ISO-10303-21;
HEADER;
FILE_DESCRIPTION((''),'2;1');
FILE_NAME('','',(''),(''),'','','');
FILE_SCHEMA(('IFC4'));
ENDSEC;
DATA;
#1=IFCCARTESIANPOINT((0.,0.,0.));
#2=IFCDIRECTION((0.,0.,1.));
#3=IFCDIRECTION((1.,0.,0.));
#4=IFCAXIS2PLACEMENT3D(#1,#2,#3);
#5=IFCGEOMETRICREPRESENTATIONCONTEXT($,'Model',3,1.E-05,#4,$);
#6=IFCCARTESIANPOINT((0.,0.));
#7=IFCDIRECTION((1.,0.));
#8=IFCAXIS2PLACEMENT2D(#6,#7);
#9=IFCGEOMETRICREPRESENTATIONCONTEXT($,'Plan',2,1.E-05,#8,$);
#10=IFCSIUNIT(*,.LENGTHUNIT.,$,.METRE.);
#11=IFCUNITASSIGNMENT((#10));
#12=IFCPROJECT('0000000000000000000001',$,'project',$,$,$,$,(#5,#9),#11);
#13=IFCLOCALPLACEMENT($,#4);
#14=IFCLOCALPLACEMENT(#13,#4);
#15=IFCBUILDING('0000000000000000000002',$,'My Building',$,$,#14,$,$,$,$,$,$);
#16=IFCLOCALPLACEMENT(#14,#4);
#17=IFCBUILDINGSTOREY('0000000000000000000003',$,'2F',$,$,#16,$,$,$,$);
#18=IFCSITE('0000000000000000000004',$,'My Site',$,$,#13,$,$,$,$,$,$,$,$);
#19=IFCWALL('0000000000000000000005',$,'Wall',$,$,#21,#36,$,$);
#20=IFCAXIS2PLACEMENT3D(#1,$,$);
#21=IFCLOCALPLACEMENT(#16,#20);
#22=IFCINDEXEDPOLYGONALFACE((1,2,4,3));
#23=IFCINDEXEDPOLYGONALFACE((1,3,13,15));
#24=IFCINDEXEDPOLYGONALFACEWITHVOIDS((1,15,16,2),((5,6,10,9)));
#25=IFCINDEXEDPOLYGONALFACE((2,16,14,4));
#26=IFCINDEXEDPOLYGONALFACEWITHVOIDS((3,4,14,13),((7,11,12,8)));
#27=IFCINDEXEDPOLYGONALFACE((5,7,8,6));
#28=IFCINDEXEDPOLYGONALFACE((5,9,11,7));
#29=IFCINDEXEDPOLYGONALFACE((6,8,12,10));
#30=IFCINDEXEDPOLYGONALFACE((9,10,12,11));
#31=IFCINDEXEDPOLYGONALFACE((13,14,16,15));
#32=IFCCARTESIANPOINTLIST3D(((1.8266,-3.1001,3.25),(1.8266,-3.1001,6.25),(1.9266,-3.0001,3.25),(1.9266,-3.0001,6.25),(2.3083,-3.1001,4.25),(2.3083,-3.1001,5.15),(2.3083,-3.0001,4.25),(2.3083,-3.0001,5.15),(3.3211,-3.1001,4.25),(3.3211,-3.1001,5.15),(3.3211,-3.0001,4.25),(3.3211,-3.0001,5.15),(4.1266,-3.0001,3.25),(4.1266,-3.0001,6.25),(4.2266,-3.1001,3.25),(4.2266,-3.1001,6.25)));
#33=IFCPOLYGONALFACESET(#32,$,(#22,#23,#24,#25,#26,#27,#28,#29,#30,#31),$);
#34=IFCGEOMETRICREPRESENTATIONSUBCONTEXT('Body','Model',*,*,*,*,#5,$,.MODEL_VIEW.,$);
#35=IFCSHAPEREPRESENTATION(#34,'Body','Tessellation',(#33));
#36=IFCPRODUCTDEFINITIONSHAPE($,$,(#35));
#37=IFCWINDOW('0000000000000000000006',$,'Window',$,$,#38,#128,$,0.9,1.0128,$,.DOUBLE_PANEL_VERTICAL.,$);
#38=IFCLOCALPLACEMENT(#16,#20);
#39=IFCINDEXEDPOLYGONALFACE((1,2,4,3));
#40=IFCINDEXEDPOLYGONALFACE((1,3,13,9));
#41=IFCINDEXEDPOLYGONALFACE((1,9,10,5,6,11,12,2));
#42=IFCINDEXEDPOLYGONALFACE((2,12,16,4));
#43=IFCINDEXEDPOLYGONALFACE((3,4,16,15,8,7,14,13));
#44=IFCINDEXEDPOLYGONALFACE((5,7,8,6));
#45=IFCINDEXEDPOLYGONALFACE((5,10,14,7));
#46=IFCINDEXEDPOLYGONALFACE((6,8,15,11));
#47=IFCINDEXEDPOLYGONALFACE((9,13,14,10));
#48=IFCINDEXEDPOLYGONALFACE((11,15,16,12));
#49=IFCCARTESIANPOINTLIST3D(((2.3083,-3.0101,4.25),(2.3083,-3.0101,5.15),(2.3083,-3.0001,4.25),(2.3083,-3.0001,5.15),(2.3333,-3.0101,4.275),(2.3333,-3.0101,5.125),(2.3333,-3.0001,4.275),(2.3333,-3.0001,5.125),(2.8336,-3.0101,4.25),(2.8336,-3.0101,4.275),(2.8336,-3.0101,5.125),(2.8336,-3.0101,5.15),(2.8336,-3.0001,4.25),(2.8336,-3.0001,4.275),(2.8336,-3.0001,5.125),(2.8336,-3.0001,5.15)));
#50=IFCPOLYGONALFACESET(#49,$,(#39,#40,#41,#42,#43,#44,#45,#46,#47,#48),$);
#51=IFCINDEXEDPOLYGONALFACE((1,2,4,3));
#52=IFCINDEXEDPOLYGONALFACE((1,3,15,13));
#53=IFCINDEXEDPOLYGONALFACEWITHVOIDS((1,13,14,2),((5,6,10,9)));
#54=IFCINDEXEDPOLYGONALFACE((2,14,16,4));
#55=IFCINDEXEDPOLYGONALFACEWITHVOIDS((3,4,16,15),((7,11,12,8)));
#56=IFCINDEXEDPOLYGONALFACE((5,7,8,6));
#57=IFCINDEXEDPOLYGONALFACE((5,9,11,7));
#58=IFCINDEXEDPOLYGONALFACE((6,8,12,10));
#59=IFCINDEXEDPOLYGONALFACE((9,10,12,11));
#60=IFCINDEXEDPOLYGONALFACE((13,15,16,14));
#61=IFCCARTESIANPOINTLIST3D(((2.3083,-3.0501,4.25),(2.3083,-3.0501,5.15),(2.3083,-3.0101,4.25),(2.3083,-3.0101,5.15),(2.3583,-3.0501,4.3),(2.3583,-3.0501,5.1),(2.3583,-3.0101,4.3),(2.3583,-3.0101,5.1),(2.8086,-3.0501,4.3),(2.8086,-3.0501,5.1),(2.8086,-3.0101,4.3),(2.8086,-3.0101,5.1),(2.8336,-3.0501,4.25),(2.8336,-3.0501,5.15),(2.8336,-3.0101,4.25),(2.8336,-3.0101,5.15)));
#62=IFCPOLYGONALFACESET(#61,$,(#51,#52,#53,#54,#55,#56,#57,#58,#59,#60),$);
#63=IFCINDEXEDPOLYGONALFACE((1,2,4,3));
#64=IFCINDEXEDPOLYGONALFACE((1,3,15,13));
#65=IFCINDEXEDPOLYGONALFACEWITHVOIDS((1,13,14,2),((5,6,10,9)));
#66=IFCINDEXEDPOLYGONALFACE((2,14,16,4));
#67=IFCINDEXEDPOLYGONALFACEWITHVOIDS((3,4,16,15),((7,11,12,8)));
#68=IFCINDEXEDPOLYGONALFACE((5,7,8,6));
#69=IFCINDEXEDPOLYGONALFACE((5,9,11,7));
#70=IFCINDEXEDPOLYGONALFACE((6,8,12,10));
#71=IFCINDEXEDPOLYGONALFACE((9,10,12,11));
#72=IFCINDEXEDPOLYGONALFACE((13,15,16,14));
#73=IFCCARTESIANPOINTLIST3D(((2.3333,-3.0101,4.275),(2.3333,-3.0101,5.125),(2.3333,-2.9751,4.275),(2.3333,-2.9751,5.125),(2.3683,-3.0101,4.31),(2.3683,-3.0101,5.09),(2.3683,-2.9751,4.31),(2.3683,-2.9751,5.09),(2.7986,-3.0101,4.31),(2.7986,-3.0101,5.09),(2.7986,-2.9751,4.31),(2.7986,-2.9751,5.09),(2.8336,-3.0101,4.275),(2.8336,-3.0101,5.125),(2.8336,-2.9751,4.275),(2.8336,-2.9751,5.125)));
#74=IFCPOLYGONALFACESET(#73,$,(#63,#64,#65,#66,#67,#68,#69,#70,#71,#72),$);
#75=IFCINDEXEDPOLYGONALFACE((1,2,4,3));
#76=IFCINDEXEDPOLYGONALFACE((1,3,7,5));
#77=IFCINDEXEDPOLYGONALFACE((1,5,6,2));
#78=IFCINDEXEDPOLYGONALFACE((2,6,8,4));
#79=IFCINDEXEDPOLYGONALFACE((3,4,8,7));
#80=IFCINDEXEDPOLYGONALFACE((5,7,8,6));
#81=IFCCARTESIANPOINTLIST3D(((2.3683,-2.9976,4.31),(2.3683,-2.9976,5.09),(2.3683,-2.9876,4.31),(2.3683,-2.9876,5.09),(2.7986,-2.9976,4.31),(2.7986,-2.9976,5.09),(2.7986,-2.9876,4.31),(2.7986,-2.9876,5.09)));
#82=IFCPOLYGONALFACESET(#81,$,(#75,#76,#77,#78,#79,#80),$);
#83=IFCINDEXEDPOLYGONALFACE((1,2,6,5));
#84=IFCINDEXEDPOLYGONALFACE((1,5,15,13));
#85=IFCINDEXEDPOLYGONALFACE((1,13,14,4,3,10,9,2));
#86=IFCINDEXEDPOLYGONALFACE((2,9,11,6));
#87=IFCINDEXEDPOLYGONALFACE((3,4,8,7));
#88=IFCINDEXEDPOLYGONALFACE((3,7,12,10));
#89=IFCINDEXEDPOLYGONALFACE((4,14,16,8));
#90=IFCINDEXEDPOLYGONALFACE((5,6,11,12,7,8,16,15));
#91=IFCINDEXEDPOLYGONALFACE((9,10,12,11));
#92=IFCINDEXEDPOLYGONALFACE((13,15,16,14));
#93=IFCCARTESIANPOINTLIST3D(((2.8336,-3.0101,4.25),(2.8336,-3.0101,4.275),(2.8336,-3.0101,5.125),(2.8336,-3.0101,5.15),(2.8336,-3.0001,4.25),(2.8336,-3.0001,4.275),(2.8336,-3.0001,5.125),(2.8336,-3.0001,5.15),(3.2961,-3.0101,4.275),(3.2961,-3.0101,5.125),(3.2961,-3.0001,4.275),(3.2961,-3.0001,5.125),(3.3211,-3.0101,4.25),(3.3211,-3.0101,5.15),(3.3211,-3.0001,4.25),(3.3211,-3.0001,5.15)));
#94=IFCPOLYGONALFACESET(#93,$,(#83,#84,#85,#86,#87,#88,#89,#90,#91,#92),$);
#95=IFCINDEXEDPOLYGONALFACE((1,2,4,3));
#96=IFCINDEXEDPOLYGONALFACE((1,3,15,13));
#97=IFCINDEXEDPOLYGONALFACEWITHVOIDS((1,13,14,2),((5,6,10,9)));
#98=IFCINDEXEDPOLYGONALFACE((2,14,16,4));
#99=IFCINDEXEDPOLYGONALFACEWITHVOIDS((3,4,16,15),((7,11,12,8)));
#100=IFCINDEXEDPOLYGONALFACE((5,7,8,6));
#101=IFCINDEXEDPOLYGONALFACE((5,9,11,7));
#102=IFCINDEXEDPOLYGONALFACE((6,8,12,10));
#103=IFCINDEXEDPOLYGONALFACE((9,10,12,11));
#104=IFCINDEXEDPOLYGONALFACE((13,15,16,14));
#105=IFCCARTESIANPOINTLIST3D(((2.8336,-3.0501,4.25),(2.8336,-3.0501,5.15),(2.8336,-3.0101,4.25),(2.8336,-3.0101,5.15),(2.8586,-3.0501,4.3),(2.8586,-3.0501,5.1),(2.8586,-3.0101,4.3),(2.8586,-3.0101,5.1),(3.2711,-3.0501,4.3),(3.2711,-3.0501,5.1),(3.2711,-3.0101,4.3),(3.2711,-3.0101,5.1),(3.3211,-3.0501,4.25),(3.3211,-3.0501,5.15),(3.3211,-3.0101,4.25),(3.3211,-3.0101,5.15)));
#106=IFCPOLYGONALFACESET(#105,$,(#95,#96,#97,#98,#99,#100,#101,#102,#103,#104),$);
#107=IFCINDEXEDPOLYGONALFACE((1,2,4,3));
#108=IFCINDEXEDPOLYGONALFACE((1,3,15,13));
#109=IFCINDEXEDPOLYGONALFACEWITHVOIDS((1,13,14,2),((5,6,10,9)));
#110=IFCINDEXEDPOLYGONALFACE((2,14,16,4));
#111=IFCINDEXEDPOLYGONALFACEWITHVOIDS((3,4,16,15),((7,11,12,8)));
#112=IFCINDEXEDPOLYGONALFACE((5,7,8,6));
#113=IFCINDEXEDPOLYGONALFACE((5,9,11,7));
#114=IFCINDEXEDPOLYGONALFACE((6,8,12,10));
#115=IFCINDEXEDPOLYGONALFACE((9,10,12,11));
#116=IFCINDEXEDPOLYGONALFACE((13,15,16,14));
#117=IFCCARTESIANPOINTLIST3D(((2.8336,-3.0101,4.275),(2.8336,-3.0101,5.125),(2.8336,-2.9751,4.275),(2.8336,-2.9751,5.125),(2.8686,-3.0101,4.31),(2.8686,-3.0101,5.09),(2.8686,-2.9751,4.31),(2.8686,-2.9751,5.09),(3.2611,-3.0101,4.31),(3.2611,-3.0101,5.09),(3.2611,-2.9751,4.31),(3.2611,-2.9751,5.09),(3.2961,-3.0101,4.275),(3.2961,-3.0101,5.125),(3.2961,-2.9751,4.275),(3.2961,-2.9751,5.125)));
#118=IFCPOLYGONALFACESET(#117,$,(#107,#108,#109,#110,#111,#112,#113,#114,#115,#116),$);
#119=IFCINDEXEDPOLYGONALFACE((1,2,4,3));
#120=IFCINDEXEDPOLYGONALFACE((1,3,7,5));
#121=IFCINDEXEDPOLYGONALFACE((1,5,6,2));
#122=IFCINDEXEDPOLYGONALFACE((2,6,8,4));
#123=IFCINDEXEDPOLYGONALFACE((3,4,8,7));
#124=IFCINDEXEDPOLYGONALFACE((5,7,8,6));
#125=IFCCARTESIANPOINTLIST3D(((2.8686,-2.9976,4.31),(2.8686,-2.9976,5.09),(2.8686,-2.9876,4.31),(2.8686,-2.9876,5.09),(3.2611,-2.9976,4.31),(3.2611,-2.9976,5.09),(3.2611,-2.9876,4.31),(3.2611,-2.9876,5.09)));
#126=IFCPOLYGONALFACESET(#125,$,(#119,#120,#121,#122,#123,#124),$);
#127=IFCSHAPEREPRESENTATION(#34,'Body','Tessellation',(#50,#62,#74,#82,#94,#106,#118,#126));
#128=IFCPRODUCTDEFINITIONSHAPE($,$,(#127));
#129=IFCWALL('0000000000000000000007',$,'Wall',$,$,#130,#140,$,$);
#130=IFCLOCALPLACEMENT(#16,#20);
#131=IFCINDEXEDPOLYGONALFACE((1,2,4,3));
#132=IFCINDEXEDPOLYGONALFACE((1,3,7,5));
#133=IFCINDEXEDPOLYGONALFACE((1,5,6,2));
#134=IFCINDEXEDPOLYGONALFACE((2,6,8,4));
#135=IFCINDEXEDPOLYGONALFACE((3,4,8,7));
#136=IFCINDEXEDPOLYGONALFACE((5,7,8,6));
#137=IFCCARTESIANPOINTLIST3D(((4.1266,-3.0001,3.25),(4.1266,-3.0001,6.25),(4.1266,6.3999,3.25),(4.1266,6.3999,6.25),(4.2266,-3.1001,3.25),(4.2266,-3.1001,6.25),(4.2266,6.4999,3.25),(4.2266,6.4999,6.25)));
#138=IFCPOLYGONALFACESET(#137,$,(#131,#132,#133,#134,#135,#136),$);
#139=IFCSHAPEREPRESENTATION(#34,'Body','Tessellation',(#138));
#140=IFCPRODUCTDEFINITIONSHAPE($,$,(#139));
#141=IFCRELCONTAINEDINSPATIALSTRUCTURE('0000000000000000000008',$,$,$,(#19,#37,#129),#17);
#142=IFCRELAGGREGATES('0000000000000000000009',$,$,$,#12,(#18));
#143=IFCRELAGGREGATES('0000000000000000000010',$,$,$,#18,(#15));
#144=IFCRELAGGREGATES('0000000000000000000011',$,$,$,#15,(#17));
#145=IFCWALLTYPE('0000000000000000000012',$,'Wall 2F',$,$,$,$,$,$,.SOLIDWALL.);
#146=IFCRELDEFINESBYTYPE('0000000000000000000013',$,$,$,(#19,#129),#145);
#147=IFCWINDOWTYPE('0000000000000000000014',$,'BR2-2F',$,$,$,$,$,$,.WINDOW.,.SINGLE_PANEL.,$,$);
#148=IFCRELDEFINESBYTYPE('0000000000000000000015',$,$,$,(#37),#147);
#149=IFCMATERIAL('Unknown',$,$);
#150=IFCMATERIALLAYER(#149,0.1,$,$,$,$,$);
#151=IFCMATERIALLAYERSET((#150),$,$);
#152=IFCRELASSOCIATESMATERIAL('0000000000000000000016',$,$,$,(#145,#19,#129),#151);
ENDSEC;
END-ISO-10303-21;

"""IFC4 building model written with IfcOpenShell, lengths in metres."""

from ifc_helpers import new_model, entity, si_unit, frame, origin_with_axes, origin_2d_with_axis, place, context, subcontext, project, spatial, line, indexed_curve, outline, extrude, shape, source, transform, mapped, material, layer, layer_set, layer_usage, type_object, type_shapes, element, fill, save


model = new_model("IFC4")

# Units and contexts
model_context = context("Model", 3, precision=1e-05, world=origin_with_axes())
plan_context = context("Plan", 2, precision=1e-05, world=origin_2d_with_axis())
body_context_1 = subcontext(model_context, "Body", "Model", "MODEL_VIEW")
body_context_2 = subcontext(plan_context, "Body", "Plan", "PLAN_VIEW")
ifc_project = project(units=[si_unit("LENGTHUNIT", "METRE")], contexts=[model_context, plan_context])

# Site, building, storey
site_placement = place(None, origin_with_axes())
site = spatial("IfcSite", under=ifc_project, at=site_placement, Name="My Site")
building_placement = place(site_placement, origin_with_axes())
building = spatial("IfcBuilding", under=site, at=building_placement, Name="My Building")
storey_placement = place(building_placement, origin_with_axes())
storey = spatial("IfcBuildingStorey", under=building, at=storey_placement, Name="2F")

# Shared definitions
ifc_material = material(Name="Unknown")

# Shared definitions
ifc_layer = layer(ifc_material, 0.1)
ifc_layer_set = layer_set([ifc_layer])
wall_type = type_object("IfcWallType", Name="Wall 2F", PredefinedType="SOLIDWALL", material=ifc_layer_set)

# Wall, opening, window
ifc_layer_usage_1 = layer_usage(ifc_layer_set, "AXIS2", "POSITIVE", 0.0)
wall_1_placement = place(storey_placement, frame((1.8266, -3.1001, 3.25), z_axis=(0.0, 0.0, 1.0), x_axis=(1.0, 0.0, 0.0)))
wall_1 = element("IfcWall", 1, at=wall_1_placement, inside=storey, type_object=wall_type, material=ifc_layer_usage_1, Name="Wall", context=body_context_1, shape_type="SweptSolid", body=[
    extrude(outline(indexed_curve([(0.0, 0.0), (0.1, 0.1), (2.3, 0.1), (2.4, 0.0)], segments=[line(1, 2, 3, 4, 1)])), origin_with_axes(), (0.0, 0.0, 1.0), 3.0),
])
shared_shape_1 = source(origin_with_axes(), body_context_1, "Body", "SweptSolid", [
    extrude(outline(indexed_curve([(0.0, 0.0), (1.0128, 0.0), (1.0128, 0.9), (0.0, 0.9)], segments=[line(1, 2, 3, 4, 1)])), frame((0.0, -0.6, 0.0), z_axis=(0.0, -1.0, 0.0), x_axis=(1.0, 0.0, 0.0)), (0.0, 0.0, -1.0), 1.2),
])
opening_1_placement = place(wall_1_placement, frame((0.4817, 0.0, 1.0), z_axis=(0.0, 0.0, 1.0), x_axis=(1.0, 0.0, 0.0)))
opening_1 = element("IfcOpeningElement", 2, at=opening_1_placement, cuts=wall_1, PredefinedType="OPENING", context=body_context_1, shape_type="MappedRepresentation", body=[
    mapped(shared_shape_1, transform((0.0, 0.0, 0.0), x_axis=(1.0, 0.0, 0.0), y_axis=(0.0, 1.0, 0.0), z_axis=(0.0, 0.0, 1.0), scale=1.0)),
])
window_type = type_object("IfcWindowType", Name="BR2-2F", PartitioningType="SINGLE_PANEL", PredefinedType="WINDOW")
shared_shape_2 = source(origin_with_axes(), body_context_1, "Body", "SweptSolid", [
    extrude(outline(indexed_curve([(0.5254, 0.0), (0.0, 0.0), (0.0, 0.9), (0.5254, 0.9), (0.5254, 0.875), (0.025, 0.875), (0.025, 0.025), (0.5254, 0.025)], segments=[line(1, 2, 3, 4, 5, 6, 7, 8, 1)])), frame((0.0, 0.09, 0.0), z_axis=(0.0, -1.0, 0.0), x_axis=(1.0, 0.0, 0.0)), (0.0, 0.0, -1.0), 0.01),
    extrude(outline(indexed_curve([(0.0, 0.0), (0.5254, 0.0), (0.5254, 0.9), (0.0, 0.9)], segments=[line(1, 2, 3, 4, 1)]), holes=[indexed_curve([(0.05, 0.05), (0.5004, 0.05), (0.5004, 0.85), (0.05, 0.85)], segments=[line(1, 2, 3, 4, 1)])]), frame((0.0, 0.05, 0.0), z_axis=(0.0, -1.0, 0.0), x_axis=(1.0, 0.0, 0.0)), (0.0, 0.0, -1.0), 0.04),
    extrude(outline(indexed_curve([(0.0, 0.0), (0.5004, 0.0), (0.5004, 0.85), (0.0, 0.85)], segments=[line(1, 2, 3, 4, 1)]), holes=[indexed_curve([(0.035, 0.035), (0.4654, 0.035), (0.4654, 0.815), (0.035, 0.815)], segments=[line(1, 2, 3, 4, 1)])]), frame((0.025, 0.09, 0.025), z_axis=(0.0, -1.0, 0.0), x_axis=(1.0, 0.0, 0.0)), (0.0, 0.0, -1.0), 0.035),
    extrude(outline(indexed_curve([(0.035, 0.035), (0.4654, 0.035), (0.4654, 0.815), (0.035, 0.815)], segments=[line(1, 2, 3, 4, 1)])), frame((0.025, 0.1025, 0.025), z_axis=(0.0, -1.0, 0.0), x_axis=(1.0, 0.0, 0.0)), (0.0, 0.0, -1.0), 0.01),
    extrude(outline(indexed_curve([(0.0, 0.9), (0.4875, 0.9), (0.4875, 0.0), (0.0, 0.0), (0.0, 0.025), (0.4625, 0.025), (0.4625, 0.875), (0.0, 0.875)], segments=[line(1, 2, 3, 4, 5, 6, 7, 8, 1)])), frame((0.5254, 0.09, 0.0), z_axis=(0.0, -1.0, 0.0), x_axis=(1.0, 0.0, 0.0)), (0.0, 0.0, -1.0), 0.01),
    extrude(outline(indexed_curve([(0.0, 0.0), (0.4875, 0.0), (0.4875, 0.9), (0.0, 0.9)], segments=[line(1, 2, 3, 4, 1)]), holes=[indexed_curve([(0.025, 0.05), (0.4375, 0.05), (0.4375, 0.85), (0.025, 0.85)], segments=[line(1, 2, 3, 4, 1)])]), frame((0.5254, 0.05, 0.0), z_axis=(0.0, -1.0, 0.0), x_axis=(1.0, 0.0, 0.0)), (0.0, 0.0, -1.0), 0.04),
    extrude(outline(indexed_curve([(0.0, 0.0), (0.4625, 0.0), (0.4625, 0.85), (0.0, 0.85)], segments=[line(1, 2, 3, 4, 1)]), holes=[indexed_curve([(0.035, 0.035), (0.4275, 0.035), (0.4275, 0.815), (0.035, 0.815)], segments=[line(1, 2, 3, 4, 1)])]), frame((0.5254, 0.09, 0.025), z_axis=(0.0, -1.0, 0.0), x_axis=(1.0, 0.0, 0.0)), (0.0, 0.0, -1.0), 0.035),
    extrude(outline(indexed_curve([(0.035, 0.035), (0.4275, 0.035), (0.4275, 0.815), (0.035, 0.815)], segments=[line(1, 2, 3, 4, 1)])), frame((0.5254, 0.1025, 0.025), z_axis=(0.0, -1.0, 0.0), x_axis=(1.0, 0.0, 0.0)), (0.0, 0.0, -1.0), 0.01),
])
shared_shape_3 = source(origin_with_axes(), body_context_2, "Body", "Curve2D", [
    entity("IfcIndexedPolyCurve", entity("IfcCartesianPointList2D", [[0.05, 0.05], [0.5004, 0.05]])),
    entity("IfcIndexedPolyCurve", entity("IfcCartesianPointList2D", [[0.0, 0.1], [0.025, 0.1], [0.025, 0.09], [0.05, 0.09], [0.05, 0.05], [0.0, 0.05]]), [entity("IfcLineIndex", [1, 2, 3, 4, 5, 6, 1])]),
    entity("IfcIndexedPolyCurve", entity("IfcCartesianPointList2D", [[0.5254, 0.1], [0.5254, 0.1], [0.5254, 0.09], [0.5004, 0.09], [0.5004, 0.05], [0.5254, 0.05]])),
    entity("IfcIndexedPolyCurve", entity("IfcCartesianPointList2D", [[0.025, 0.09], [0.06, 0.09], [0.06, 0.125], [0.025, 0.125]]), [entity("IfcLineIndex", [1, 2, 3, 4, 1])]),
    entity("IfcIndexedPolyCurve", entity("IfcCartesianPointList2D", [[0.5254, 0.09], [0.4904, 0.09], [0.4904, 0.125], [0.5254, 0.125]]), [entity("IfcLineIndex", [1, 2, 3, 4, 1])]),
    entity("IfcIndexedPolyCurve", entity("IfcCartesianPointList2D", [[0.06, 0.09], [0.4904, 0.09]])),
    entity("IfcIndexedPolyCurve", entity("IfcCartesianPointList2D", [[0.06, 0.125], [0.4904, 0.125]])),
    entity("IfcIndexedPolyCurve", entity("IfcCartesianPointList2D", [[0.06, 0.1075], [0.4904, 0.1075]])),
    entity("IfcIndexedPolyCurve", entity("IfcCartesianPointList2D", [[0.5504, 0.05], [0.9628, 0.05]])),
    entity("IfcIndexedPolyCurve", entity("IfcCartesianPointList2D", [[0.5254, 0.1], [0.5254, 0.1], [0.5254, 0.09], [0.5504, 0.09], [0.5504, 0.05], [0.5254, 0.05]])),
    entity("IfcIndexedPolyCurve", entity("IfcCartesianPointList2D", [[1.0128, 0.1], [0.9878, 0.1], [0.9878, 0.09], [0.9628, 0.09], [0.9628, 0.05], [1.0128, 0.05]]), [entity("IfcLineIndex", [1, 2, 3, 4, 5, 6, 1])]),
    entity("IfcIndexedPolyCurve", entity("IfcCartesianPointList2D", [[0.5254, 0.09], [0.5604, 0.09], [0.5604, 0.125], [0.5254, 0.125]]), [entity("IfcLineIndex", [1, 2, 3, 4, 1])]),
    entity("IfcIndexedPolyCurve", entity("IfcCartesianPointList2D", [[0.9878, 0.09], [0.9528, 0.09], [0.9528, 0.125], [0.9878, 0.125]]), [entity("IfcLineIndex", [1, 2, 3, 4, 1])]),
    entity("IfcIndexedPolyCurve", entity("IfcCartesianPointList2D", [[0.5604, 0.09], [0.9528, 0.09]])),
    entity("IfcIndexedPolyCurve", entity("IfcCartesianPointList2D", [[0.5604, 0.125], [0.9528, 0.125]])),
    entity("IfcIndexedPolyCurve", entity("IfcCartesianPointList2D", [[0.5604, 0.1075], [0.9528, 0.1075]])),
])
type_shapes(window_type, [shared_shape_2, shared_shape_3])
window_placement = place(opening_1_placement, frame((0.0, 0.0, 0.0), z_axis=(0.0, 0.0, 1.0), x_axis=(1.0, 0.0, 0.0)))
window = element("IfcWindow", 3, at=window_placement, inside=storey, type_object=window_type, Name="Window", OverallHeight=0.9, OverallWidth=1.0128, PartitioningType="DOUBLE_PANEL_VERTICAL", shapes=[
    shape(body_context_1, "Body", "MappedRepresentation", [mapped(shared_shape_2, transform((0.0, 0.0, 0.0), x_axis=(1.0, 0.0, 0.0), y_axis=(0.0, 1.0, 0.0), z_axis=(0.0, 0.0, 1.0), scale=1.0))]),
    shape(body_context_2, "Body", "MappedRepresentation", [mapped(shared_shape_3, transform((0.0, 0.0, 0.0), x_axis=(1.0, 0.0, 0.0), y_axis=(0.0, 1.0, 0.0), z_axis=(0.0, 0.0, 1.0), scale=1.0))]),
])
fill(opening_1, window)

# Wall
ifc_layer_usage_2 = layer_usage(ifc_layer_set, "AXIS2", "POSITIVE", 0.0)
wall_2_placement = place(storey_placement, frame((4.2266, -3.1001, 3.25), z_axis=(0.0, 0.0, 1.0), x_axis=(0.0, 1.0, 0.0)))
element("IfcWall", 4, at=wall_2_placement, inside=storey, type_object=wall_type, material=ifc_layer_usage_2, Name="Wall", context=body_context_1, shape_type="SweptSolid", body=[
    extrude(outline(indexed_curve([(0.0, 0.0), (0.1, 0.1), (9.5, 0.1), (9.6, 0.0)], segments=[line(1, 2, 3, 4, 1)])), origin_with_axes(), (0.0, 0.0, 1.0), 3.0),
])

save(model, "model.ifc")
